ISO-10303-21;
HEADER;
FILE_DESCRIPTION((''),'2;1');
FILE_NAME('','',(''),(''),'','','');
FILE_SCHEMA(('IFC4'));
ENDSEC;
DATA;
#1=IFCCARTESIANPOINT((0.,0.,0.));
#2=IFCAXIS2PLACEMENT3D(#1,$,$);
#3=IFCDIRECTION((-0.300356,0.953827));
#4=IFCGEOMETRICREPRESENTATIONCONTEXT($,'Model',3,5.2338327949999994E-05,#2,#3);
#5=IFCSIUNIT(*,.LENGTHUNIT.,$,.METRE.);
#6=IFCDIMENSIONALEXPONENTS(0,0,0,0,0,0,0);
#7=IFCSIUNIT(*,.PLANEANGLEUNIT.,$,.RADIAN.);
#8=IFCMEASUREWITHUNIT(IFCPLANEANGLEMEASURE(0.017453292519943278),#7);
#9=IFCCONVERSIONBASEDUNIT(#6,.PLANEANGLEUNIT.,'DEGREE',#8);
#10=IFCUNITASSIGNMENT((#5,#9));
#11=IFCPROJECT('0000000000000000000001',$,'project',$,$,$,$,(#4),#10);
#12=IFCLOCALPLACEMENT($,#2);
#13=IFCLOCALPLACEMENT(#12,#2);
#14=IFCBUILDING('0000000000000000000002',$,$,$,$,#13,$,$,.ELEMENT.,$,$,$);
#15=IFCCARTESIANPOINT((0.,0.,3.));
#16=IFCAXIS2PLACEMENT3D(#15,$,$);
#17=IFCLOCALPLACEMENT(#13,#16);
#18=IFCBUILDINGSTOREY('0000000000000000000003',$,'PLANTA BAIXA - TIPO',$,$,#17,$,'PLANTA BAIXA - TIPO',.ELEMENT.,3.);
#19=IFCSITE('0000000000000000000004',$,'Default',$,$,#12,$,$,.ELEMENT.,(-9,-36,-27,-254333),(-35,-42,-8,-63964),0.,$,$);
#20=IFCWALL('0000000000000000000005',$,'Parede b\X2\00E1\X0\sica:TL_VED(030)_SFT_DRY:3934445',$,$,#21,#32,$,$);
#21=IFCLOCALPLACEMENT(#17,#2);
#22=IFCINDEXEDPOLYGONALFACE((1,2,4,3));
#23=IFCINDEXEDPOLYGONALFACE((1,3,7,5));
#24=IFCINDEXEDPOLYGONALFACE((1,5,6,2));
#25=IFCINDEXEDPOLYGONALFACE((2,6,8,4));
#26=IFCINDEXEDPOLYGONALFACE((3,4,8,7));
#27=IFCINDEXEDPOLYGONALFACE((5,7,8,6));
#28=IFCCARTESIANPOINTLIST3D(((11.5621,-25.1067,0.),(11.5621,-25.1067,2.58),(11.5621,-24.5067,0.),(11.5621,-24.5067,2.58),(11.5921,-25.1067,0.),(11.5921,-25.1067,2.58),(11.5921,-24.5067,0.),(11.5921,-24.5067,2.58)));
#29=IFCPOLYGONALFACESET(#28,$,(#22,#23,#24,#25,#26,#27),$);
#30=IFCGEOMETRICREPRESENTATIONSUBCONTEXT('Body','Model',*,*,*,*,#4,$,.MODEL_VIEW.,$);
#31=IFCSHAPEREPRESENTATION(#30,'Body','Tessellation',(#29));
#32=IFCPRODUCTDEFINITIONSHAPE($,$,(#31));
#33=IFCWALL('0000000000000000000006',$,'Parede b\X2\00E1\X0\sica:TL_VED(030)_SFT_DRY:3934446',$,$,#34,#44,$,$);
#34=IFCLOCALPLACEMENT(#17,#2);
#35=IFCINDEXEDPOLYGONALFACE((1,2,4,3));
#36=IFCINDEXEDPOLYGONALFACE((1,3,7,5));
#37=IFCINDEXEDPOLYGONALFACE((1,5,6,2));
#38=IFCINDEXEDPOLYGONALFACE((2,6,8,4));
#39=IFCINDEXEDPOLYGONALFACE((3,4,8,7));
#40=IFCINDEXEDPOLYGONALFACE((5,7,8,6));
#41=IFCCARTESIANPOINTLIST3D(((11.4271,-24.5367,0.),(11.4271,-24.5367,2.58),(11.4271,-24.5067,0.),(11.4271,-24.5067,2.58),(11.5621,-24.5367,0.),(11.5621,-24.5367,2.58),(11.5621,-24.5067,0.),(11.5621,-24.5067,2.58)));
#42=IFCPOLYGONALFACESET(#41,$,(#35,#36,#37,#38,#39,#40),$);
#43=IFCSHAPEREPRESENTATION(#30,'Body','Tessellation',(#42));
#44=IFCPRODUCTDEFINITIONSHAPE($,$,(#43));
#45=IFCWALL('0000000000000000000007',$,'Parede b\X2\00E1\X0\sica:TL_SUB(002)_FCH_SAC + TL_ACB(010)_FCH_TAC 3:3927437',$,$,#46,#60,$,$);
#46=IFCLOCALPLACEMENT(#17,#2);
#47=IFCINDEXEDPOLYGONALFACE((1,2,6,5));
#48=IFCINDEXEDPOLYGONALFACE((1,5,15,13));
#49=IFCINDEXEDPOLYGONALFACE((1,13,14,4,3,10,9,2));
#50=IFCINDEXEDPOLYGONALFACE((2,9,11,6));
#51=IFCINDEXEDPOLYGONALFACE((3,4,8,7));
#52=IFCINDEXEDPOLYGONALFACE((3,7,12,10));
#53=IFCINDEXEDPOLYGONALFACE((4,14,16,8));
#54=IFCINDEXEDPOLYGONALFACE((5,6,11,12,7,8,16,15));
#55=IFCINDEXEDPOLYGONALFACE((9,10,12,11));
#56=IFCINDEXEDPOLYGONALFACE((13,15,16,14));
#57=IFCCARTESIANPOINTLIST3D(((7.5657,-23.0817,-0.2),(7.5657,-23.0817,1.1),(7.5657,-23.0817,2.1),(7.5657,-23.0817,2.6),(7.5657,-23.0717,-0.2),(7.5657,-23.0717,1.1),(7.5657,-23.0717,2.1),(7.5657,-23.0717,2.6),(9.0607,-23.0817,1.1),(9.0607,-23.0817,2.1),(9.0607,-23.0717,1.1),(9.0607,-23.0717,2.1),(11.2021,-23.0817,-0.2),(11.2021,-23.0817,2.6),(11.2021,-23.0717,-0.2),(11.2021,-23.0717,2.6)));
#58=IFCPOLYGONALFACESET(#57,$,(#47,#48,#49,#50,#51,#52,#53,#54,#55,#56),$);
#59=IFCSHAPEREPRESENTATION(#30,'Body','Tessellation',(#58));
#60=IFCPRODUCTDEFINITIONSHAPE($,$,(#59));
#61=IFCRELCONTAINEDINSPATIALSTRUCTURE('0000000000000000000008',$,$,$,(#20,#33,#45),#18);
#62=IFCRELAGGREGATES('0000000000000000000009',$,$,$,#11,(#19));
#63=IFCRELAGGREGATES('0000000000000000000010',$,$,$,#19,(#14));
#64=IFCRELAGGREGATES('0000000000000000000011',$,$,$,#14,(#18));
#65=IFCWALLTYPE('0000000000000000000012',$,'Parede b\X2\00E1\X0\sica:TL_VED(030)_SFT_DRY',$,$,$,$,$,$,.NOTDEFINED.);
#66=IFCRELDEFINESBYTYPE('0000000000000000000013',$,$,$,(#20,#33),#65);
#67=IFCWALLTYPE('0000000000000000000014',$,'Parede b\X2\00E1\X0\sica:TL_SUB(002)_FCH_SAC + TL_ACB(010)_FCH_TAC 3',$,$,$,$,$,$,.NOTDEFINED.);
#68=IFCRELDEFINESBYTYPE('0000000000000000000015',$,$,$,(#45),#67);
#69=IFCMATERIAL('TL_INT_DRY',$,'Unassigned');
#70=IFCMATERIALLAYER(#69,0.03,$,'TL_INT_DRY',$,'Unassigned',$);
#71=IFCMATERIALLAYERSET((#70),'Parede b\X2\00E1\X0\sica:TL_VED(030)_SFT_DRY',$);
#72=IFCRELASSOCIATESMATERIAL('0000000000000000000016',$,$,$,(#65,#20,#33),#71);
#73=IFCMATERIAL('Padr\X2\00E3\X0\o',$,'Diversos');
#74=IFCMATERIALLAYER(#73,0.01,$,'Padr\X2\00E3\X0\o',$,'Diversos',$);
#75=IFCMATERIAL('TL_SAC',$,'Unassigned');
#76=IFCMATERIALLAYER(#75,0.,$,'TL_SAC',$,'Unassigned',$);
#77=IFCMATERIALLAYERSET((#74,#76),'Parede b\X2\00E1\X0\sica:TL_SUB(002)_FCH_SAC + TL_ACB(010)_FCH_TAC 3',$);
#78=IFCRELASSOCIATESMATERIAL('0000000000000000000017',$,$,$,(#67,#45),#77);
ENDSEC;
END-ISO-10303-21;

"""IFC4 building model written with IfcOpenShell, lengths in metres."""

from ifc_helpers import new_model, entity, si_unit, converted_unit, direction, frame, frame_2d, origin, place, context, subcontext, project, spatial, rectangle, extrude, material, layer, layer_set, layer_usage, type_object, element, save


model = new_model("IFC4")

# Units and contexts
model_context = context("Model", 3, precision=5.2338327949999994e-05, world=origin(), true_north=direction((-0.300356, 0.953827)))
body_context = subcontext(model_context, "Body", "Model", "MODEL_VIEW")
ifc_project = project(units=[si_unit("LENGTHUNIT", "METRE"), converted_unit("PLANEANGLEUNIT", "DEGREE", entity("IfcPlaneAngleMeasure", 0.017453292519943278), si_unit("PLANEANGLEUNIT", "RADIAN"), dimensions=[0, 0, 0, 0, 0, 0, 0])], contexts=[model_context])

# Site, building, storey
site_placement = place(None, origin())
site = spatial("IfcSite", under=ifc_project, at=site_placement, Name="Default", CompositionType="ELEMENT", RefLatitude=(-9, -36, -27, -254333), RefLongitude=(-35, -42, -8, -63964), RefElevation=0.0)
building_placement = place(site_placement, origin())
building = spatial("IfcBuilding", under=site, at=building_placement, CompositionType="ELEMENT")
storey_placement = place(building_placement, frame((0.0, 0.0, 3.0)))
storey = spatial("IfcBuildingStorey", under=building, at=storey_placement, Name="PLANTA BAIXA - TIPO", LongName="PLANTA BAIXA - TIPO", CompositionType="ELEMENT", Elevation=3.0)

# Shared definitions
ifc_material_1 = material(Name="TL_SAC", Category="Unassigned")

# Walls
ifc_material_2 = material(Name="TL_INT_DRY", Category="Unassigned")
ifc_layer_1 = layer(ifc_material_2, 0.03, Name="TL_INT_DRY", Category="Unassigned")
ifc_layer_set_1 = layer_set([ifc_layer_1], Name="Parede básica:TL_VED(030)_SFT_DRY")
ifc_layer_usage_1 = layer_usage(ifc_layer_set_1, "AXIS2", "POSITIVE", -0.015)
wall_type_1 = type_object("IfcWallType", Name="Parede básica:TL_VED(030)_SFT_DRY", PredefinedType="NOTDEFINED", material=ifc_layer_set_1)
wall_1_placement = place(storey_placement, frame((11.5771, -25.1067, 0.0), z_axis=(0.0, 0.0, 1.0), x_axis=(0.0, 1.0, 0.0)))
element("IfcWall", 1, at=wall_1_placement, inside=storey, type_object=wall_type_1, material=ifc_layer_usage_1, Name="Parede básica:TL_VED(030)_SFT_DRY:3934445", context=body_context, shape_type="SweptSolid", body=[
    extrude(rectangle(XDim=0.6, YDim=0.03, at=frame_2d((0.3, 0.0), x_axis=(-1.0, 0.0))), origin(), (0.0, 0.0, 1.0), 2.58),
])
ifc_layer_usage_2 = layer_usage(ifc_layer_set_1, "AXIS2", "POSITIVE", -0.015)
wall_2_placement = place(storey_placement, frame((11.5621, -24.5217, 0.0), z_axis=(0.0, 0.0, 1.0), x_axis=(-1.0, 0.0, 0.0)))
element("IfcWall", 2, at=wall_2_placement, inside=storey, type_object=wall_type_1, material=ifc_layer_usage_2, Name="Parede básica:TL_VED(030)_SFT_DRY:3934446", context=body_context, shape_type="SweptSolid", body=[
    extrude(rectangle(XDim=0.135, YDim=0.03, at=frame_2d((0.0675, 0.0), x_axis=(-1.0, 0.0))), origin(), (0.0, 0.0, 1.0), 2.58),
])

# Wall, opening
ifc_material_3 = material(Name="Padrão", Category="Diversos")
ifc_layer_2 = layer(ifc_material_3, 0.01, Name="Padrão", Category="Diversos")
ifc_layer_3 = layer(ifc_material_1, 0.0, Name="TL_SAC", Category="Unassigned")
ifc_layer_set_2 = layer_set([ifc_layer_2, ifc_layer_3], Name="Parede básica:TL_SUB(002)_FCH_SAC + TL_ACB(010)_FCH_TAC 3")
ifc_layer_usage_3 = layer_usage(ifc_layer_set_2, "AXIS2", "NEGATIVE", 0.005)
wall_type_2 = type_object("IfcWallType", Name="Parede básica:TL_SUB(002)_FCH_SAC + TL_ACB(010)_FCH_TAC 3", PredefinedType="NOTDEFINED", material=ifc_layer_set_2)
wall_3_placement = place(storey_placement, frame((7.5657, -23.0767, -0.2)))
wall_3 = element("IfcWall", 3, at=wall_3_placement, inside=storey, type_object=wall_type_2, material=ifc_layer_usage_3, Name="Parede básica:TL_SUB(002)_FCH_SAC + TL_ACB(010)_FCH_TAC 3:3927437", context=body_context, shape_type="SweptSolid", body=[
    extrude(rectangle(XDim=3.6364, YDim=0.01, at=frame_2d((1.8182, 0.0), x_axis=(-1.0, 0.0))), origin(), (0.0, 0.0, 1.0), 2.8),
])
opening_1_placement = place(wall_3_placement, frame((-7.5657, 23.0767, 1.3)))
element("IfcOpeningElement", 4, at=opening_1_placement, cuts=wall_3, PredefinedType="OPENING", context=body_context, shape_type="SweptSolid", body=[
    extrude(rectangle(XDim=1.0, YDim=1.5, at=frame_2d((0.0, 0.0), x_axis=(1.0, 0.0))), frame((8.3107, -24.4457, 0.5), z_axis=(0.0, 1.0, 0.0), x_axis=(0.0, 0.0, -1.0)), (0.0, 0.0, 1.0), 3.048),
])

save(model, "model.ifc")
